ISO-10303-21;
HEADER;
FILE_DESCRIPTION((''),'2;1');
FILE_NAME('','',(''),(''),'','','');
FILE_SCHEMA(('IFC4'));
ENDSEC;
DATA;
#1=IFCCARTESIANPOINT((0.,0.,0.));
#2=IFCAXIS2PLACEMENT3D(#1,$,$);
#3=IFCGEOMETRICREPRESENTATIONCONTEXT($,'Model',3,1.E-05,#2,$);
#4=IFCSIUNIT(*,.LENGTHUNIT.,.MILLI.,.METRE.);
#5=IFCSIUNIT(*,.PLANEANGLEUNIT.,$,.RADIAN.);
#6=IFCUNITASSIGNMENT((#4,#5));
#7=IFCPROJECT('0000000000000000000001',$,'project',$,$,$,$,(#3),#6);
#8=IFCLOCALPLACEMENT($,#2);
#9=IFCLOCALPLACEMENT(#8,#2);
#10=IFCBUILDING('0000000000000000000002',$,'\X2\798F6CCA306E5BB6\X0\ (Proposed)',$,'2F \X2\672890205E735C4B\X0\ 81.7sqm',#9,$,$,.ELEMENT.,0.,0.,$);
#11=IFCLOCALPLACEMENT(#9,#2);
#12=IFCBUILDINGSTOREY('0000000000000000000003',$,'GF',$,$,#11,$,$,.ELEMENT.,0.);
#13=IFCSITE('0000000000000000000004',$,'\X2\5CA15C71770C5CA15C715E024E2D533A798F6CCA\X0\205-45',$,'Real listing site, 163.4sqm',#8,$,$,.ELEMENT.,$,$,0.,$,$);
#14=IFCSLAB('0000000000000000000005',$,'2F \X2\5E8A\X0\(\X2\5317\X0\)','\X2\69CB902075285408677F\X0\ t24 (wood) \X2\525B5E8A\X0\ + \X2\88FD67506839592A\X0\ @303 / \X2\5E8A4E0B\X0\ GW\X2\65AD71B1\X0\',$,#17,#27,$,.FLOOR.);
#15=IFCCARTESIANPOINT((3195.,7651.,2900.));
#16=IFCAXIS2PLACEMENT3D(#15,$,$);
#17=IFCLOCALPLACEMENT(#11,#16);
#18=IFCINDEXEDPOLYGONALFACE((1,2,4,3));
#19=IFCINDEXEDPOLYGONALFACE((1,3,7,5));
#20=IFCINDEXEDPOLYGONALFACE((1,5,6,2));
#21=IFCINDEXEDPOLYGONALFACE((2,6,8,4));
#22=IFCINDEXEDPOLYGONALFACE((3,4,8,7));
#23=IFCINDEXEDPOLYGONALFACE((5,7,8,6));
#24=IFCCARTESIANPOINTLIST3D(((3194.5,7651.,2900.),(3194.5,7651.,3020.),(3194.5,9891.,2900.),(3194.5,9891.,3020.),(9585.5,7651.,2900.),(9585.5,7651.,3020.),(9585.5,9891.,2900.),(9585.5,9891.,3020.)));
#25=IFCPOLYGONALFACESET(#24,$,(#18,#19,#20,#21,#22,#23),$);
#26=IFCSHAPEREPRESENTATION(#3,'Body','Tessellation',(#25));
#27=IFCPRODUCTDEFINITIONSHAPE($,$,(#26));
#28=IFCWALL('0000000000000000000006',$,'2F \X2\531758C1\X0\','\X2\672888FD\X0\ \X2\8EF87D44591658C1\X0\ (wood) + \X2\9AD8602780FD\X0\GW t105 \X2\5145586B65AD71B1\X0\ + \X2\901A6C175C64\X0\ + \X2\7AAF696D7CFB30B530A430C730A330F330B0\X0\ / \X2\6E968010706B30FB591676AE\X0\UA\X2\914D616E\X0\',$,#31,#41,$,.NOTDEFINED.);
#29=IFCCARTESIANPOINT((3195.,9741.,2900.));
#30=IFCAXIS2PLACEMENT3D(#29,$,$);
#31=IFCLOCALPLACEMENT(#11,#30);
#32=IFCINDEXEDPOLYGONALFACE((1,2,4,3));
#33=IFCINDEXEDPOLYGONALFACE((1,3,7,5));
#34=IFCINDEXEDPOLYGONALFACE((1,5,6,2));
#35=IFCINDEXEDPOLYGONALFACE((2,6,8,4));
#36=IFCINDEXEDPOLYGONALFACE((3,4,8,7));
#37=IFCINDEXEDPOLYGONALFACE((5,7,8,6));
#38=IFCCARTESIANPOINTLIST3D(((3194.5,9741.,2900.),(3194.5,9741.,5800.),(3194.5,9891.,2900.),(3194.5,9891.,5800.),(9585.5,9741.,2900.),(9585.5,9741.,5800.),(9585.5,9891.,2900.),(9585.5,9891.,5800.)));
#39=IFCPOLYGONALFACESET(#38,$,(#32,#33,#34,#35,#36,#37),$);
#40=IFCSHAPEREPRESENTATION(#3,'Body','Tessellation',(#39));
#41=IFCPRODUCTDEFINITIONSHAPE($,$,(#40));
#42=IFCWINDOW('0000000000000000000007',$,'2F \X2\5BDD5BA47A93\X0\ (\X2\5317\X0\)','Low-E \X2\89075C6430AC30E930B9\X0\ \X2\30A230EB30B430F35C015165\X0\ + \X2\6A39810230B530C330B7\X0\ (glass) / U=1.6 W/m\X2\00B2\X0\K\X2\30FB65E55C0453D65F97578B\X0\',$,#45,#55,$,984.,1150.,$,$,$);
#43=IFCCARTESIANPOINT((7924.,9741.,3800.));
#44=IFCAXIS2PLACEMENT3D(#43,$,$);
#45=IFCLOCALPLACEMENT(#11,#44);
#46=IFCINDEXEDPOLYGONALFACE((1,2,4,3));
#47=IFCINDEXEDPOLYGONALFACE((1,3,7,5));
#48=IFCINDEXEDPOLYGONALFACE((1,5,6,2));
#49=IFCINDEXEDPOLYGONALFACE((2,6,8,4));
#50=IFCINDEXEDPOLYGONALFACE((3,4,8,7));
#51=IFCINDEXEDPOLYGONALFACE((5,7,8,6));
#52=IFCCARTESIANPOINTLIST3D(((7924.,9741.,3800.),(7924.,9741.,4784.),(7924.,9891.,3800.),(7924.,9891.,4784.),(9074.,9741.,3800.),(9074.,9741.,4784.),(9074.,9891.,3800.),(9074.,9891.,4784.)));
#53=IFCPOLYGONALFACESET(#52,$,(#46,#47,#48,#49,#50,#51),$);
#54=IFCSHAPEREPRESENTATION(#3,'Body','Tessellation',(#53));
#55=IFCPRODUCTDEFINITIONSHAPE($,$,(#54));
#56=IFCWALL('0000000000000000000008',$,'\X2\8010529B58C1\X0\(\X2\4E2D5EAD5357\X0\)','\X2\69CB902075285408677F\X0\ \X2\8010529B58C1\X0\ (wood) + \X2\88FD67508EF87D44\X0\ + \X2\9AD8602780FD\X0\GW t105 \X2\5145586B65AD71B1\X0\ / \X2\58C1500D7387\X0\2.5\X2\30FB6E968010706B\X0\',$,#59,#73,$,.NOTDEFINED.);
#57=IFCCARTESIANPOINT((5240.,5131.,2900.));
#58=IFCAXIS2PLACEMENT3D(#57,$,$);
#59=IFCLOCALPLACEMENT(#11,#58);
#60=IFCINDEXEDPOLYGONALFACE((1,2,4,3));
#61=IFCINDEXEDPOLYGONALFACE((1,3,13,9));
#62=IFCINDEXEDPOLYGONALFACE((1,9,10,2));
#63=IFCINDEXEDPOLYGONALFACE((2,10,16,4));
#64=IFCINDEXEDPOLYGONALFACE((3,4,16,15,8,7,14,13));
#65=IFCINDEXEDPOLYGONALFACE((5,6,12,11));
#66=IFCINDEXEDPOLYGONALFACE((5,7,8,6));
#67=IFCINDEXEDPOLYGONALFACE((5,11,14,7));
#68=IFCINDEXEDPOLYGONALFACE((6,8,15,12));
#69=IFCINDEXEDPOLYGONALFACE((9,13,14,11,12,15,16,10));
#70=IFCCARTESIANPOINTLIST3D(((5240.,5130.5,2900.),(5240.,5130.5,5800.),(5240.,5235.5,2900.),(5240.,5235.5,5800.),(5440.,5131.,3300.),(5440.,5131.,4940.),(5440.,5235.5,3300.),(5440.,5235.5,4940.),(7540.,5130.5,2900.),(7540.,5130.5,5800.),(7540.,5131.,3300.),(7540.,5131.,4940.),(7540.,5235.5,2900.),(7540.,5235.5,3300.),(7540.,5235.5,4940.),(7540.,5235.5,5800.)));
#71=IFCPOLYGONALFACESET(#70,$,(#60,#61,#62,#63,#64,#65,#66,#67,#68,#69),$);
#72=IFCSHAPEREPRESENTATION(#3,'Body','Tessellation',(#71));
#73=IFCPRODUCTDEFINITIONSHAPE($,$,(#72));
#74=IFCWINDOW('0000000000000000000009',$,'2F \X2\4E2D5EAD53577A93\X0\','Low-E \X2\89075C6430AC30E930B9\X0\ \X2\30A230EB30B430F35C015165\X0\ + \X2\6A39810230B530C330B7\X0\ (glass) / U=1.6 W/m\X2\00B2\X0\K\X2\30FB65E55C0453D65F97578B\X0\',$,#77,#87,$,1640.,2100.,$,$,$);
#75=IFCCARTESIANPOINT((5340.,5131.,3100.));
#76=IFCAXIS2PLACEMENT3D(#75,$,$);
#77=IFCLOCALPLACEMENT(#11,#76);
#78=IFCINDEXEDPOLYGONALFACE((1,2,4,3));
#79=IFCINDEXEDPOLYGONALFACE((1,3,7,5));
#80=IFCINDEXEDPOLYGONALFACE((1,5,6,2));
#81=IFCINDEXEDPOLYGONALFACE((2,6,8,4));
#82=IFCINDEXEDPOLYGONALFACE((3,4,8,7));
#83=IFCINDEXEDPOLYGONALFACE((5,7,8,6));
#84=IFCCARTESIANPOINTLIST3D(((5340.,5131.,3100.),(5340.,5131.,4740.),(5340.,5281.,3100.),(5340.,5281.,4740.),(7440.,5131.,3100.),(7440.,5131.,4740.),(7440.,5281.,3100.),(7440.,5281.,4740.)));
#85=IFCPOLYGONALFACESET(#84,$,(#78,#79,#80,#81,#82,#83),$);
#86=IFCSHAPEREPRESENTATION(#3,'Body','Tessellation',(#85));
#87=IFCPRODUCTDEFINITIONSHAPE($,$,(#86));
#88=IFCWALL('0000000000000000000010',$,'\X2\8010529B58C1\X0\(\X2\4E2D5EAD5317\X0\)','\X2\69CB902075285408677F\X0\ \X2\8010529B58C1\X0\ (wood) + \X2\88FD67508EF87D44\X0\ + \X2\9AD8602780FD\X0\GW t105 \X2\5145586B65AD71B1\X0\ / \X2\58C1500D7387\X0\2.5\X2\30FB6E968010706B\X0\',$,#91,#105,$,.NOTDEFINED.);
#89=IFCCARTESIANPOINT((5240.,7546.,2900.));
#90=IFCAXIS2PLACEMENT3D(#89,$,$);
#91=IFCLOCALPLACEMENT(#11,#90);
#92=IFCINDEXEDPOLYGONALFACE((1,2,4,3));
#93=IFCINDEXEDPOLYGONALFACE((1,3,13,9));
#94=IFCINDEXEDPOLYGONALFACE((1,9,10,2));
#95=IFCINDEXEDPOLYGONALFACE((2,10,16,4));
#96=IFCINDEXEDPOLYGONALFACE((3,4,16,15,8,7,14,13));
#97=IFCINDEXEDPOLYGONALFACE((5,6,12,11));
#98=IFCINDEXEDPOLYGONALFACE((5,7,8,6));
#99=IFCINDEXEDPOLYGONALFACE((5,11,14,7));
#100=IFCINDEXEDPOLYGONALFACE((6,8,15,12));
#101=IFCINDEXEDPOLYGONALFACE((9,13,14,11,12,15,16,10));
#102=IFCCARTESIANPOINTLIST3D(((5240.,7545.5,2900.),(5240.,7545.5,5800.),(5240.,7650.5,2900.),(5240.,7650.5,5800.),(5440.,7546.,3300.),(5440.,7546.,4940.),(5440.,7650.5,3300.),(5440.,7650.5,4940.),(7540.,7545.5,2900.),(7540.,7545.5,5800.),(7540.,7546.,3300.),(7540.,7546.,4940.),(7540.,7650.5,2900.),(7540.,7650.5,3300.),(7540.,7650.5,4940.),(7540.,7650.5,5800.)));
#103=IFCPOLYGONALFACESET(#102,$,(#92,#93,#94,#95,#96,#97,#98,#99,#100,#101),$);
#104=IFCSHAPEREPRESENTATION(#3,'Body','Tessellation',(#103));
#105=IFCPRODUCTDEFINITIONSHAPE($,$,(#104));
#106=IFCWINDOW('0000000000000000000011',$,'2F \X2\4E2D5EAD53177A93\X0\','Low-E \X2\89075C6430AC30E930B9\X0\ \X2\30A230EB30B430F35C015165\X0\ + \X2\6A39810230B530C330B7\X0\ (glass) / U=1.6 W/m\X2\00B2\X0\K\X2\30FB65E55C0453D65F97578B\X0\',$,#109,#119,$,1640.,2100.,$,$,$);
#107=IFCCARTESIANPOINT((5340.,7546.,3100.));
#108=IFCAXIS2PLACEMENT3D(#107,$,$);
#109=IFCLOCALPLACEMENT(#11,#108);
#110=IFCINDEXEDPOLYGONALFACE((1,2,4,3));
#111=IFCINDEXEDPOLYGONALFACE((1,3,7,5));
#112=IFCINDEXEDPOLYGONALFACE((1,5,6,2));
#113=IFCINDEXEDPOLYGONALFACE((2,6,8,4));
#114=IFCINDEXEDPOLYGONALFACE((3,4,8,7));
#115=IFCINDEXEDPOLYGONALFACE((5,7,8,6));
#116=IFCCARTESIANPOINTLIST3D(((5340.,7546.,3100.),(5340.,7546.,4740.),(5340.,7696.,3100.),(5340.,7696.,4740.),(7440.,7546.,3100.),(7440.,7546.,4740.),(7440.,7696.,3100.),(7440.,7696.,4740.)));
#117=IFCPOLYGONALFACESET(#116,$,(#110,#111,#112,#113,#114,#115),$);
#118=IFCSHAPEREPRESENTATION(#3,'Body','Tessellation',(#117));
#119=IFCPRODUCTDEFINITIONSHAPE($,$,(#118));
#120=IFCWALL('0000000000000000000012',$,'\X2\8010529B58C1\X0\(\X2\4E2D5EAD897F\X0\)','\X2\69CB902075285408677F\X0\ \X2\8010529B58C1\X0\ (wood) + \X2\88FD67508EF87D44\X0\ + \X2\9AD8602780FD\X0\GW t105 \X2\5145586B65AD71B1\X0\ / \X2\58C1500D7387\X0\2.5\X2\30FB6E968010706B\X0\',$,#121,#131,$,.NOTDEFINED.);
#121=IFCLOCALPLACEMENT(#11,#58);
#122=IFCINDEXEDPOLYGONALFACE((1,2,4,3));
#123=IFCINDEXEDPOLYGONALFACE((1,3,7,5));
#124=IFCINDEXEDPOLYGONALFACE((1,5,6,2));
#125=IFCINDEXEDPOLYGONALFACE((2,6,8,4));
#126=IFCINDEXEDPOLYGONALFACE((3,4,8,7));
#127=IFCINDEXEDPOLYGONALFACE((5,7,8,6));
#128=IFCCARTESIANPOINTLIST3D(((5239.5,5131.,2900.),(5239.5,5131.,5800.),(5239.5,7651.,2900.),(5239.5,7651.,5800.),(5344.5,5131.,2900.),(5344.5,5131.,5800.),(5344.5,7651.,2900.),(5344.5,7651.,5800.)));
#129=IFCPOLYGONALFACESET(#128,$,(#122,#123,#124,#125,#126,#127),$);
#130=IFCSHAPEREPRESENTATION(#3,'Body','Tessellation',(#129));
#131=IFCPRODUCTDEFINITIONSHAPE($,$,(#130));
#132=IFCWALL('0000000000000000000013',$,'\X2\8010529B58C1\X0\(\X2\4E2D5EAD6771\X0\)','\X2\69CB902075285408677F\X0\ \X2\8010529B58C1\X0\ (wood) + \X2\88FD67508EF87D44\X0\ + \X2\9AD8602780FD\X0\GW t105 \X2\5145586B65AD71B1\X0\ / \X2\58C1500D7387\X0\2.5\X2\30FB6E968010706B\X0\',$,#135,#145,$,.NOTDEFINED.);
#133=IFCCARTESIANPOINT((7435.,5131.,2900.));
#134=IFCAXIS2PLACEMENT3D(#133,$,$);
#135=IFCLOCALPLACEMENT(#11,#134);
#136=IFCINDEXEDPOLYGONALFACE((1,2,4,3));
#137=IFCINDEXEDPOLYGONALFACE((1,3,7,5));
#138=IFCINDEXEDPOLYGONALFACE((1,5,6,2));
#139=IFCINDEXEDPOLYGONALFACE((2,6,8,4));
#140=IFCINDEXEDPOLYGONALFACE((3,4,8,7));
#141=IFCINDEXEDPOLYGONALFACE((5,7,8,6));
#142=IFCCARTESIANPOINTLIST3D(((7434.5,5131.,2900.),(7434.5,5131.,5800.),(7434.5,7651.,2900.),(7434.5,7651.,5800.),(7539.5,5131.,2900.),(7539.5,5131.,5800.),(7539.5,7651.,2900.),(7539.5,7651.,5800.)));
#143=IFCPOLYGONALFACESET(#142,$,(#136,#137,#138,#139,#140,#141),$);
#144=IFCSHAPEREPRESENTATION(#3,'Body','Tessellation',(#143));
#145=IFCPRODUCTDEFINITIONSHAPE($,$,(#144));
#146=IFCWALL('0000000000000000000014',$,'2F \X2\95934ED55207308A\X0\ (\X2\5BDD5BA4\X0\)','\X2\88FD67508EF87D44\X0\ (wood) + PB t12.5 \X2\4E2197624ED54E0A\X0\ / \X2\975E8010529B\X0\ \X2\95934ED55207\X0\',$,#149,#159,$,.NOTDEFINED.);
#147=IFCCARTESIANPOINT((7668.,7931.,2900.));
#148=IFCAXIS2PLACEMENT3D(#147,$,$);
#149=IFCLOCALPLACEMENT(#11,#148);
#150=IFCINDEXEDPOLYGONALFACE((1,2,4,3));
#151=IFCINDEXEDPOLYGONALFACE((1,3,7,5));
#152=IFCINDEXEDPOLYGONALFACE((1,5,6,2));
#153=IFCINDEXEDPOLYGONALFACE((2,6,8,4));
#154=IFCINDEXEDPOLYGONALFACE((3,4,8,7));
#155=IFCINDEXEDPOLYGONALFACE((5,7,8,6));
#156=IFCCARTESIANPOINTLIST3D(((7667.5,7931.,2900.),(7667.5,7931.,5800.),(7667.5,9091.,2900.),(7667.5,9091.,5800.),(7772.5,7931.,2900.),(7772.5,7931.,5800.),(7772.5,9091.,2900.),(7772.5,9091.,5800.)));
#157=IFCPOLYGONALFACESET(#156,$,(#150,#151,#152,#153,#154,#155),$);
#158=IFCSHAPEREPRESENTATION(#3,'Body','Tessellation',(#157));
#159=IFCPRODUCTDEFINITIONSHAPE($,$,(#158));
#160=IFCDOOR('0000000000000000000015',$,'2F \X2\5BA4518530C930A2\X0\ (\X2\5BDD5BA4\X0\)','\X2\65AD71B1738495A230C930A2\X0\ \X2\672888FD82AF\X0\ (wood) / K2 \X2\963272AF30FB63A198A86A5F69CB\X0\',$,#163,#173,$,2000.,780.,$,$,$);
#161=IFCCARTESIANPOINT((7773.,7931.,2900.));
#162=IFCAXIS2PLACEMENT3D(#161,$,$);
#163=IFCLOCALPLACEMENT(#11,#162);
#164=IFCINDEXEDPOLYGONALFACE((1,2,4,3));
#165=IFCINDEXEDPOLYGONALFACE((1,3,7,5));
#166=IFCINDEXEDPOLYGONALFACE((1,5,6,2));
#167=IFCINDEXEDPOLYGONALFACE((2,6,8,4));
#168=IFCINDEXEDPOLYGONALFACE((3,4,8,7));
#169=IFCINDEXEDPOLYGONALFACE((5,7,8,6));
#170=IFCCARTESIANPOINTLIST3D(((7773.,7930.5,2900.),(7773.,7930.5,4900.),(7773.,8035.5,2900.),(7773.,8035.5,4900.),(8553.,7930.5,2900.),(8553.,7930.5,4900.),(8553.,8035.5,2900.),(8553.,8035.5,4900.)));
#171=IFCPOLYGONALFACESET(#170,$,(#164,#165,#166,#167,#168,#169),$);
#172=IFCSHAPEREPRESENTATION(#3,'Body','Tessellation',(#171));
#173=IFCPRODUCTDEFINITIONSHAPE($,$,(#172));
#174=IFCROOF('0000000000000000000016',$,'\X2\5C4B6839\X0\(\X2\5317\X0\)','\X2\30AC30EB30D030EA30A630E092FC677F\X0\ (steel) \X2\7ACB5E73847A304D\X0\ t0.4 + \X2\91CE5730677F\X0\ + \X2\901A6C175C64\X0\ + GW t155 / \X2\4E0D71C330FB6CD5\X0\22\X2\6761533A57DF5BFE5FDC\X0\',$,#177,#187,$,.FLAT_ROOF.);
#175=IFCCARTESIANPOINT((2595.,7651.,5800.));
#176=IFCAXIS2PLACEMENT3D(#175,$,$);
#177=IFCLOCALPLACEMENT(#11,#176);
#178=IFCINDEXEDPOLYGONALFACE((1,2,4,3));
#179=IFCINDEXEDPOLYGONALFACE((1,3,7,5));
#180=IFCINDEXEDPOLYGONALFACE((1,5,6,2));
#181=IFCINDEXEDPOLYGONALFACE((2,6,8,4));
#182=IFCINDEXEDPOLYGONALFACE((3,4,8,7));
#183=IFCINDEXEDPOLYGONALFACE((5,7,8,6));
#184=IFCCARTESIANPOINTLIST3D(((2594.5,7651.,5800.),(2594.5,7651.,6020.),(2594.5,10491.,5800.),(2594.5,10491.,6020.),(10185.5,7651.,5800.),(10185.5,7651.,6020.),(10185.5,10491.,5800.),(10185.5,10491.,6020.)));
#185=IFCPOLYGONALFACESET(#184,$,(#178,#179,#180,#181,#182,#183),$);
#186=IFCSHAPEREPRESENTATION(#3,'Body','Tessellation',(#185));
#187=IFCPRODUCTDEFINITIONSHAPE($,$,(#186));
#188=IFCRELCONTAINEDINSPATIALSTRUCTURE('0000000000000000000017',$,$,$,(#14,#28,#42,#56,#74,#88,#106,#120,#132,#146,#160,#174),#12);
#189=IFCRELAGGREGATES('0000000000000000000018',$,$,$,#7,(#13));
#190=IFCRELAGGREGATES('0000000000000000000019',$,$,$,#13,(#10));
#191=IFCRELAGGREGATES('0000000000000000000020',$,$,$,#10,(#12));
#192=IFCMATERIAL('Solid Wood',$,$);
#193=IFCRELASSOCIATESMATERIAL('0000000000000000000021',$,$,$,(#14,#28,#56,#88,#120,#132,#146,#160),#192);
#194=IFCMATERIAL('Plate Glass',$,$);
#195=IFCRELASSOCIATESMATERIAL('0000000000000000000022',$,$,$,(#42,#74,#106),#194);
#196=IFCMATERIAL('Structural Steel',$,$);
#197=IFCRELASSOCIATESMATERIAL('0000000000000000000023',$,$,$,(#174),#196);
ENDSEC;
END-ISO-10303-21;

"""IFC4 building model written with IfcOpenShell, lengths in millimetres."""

from ifc_helpers import new_model, si_unit, frame, frame_2d, origin, place, context, project, spatial, rectangle, extrude, material, element, fill, save


model = new_model("IFC4")

# Units and contexts
model_context = context("Model", 3, precision=1e-05, world=origin())
ifc_project = project(units=[si_unit("LENGTHUNIT", "METRE", prefix="MILLI"), si_unit("PLANEANGLEUNIT", "RADIAN")], contexts=[model_context])

# Site, building, storey
site_placement = place(None, origin())
site = spatial("IfcSite", under=ifc_project, at=site_placement, Name="岡山県岡山市中区福泊205-45", ObjectType="Real listing site, 163.4sqm", CompositionType="ELEMENT", RefElevation=0.0)
building_placement = place(site_placement, origin())
building = spatial("IfcBuilding", under=site, at=building_placement, Name="福泊の家 (Proposed)", ObjectType="2F 木造平屋 81.7sqm", CompositionType="ELEMENT", ElevationOfRefHeight=0.0, ElevationOfTerrain=0.0)
storey_placement = place(building_placement, origin())
storey = spatial("IfcBuildingStorey", under=building, at=storey_placement, Name="GF", CompositionType="ELEMENT", Elevation=0.0)

# Slab
ifc_material_1 = material(Name="Solid Wood")
slab_placement = place(storey_placement, frame((3195.0, 7651.0, 2900.0)))
element("IfcSlab", 1, at=slab_placement, inside=storey, material=ifc_material_1, Name="2F 床(北)", Description="構造用合板 t24 (wood) 剛床 + 製材根太 @303 / 床下 GW断熱", PredefinedType="FLOOR", context=model_context, shape_type="SweptSolid", body=[
    extrude(rectangle(XDim=6391.0, YDim=2240.0, at=frame_2d((3195.0, 1120.0))), frame((3195.0, 7651.0, 2900.0)), (0.0, 0.0, 1.0), 120.0),
])

# Walls, openings, windows
wall_1_placement = place(storey_placement, frame((3195.0, 9741.0, 2900.0)))
wall_1 = element("IfcWall", 2, at=wall_1_placement, inside=storey, material=ifc_material_1, Name="2F 北壁", Description="木製 軸組外壁 (wood) + 高性能GW t105 充填断熱 + 通気層 + 窯業系サイディング / 準耐火・外皮UA配慮", PredefinedType="NOTDEFINED", context=model_context, shape_type="SweptSolid", body=[
    extrude(rectangle(XDim=6391.0, YDim=150.0, at=frame_2d((3195.0, 75.0))), frame((3195.0, 9741.0, 2900.0)), (0.0, 0.0, 1.0), 2900.0),
])
opening_1_placement = place(storey_placement, frame((7924.0, 9741.0, 3800.0)))
opening_1 = element("IfcOpeningElement", 3, at=opening_1_placement, cuts=wall_1, PredefinedType="NOTDEFINED", context=model_context, shape_type="SweptSolid", body=[
    extrude(rectangle(XDim=1150.0, YDim=150.0, at=frame_2d((575.0, 75.0))), frame((7924.0, 9741.0, 3800.0)), (0.0, 0.0, 1.0), 984.0),
])
ifc_material_2 = material(Name="Plate Glass")
window_1_placement = place(storey_placement, frame((7924.0, 9741.0, 3800.0)))
window_1 = element("IfcWindow", 4, at=window_1_placement, inside=storey, material=ifc_material_2, Name="2F 寝室窓 (北)", Description="Low-E 複層ガラス アルゴン封入 + 樹脂サッシ (glass) / U=1.6 W/m²K・日射取得型", OverallHeight=984.0, OverallWidth=1150.0, context=model_context, shape_type="SweptSolid", body=[
    extrude(rectangle(XDim=1150.0, YDim=150.0, at=frame_2d((575.0, 75.0))), frame((7924.0, 9741.0, 3800.0)), (0.0, 0.0, 1.0), 984.0),
])
fill(opening_1, window_1)
wall_2_placement = place(storey_placement, frame((5240.0, 5131.0, 2900.0)))
wall_2 = element("IfcWall", 5, at=wall_2_placement, inside=storey, material=ifc_material_1, Name="耐力壁(中庭南)", Description="構造用合板 耐力壁 (wood) + 製材軸組 + 高性能GW t105 充填断熱 / 壁倍率2.5・準耐火", PredefinedType="NOTDEFINED", context=model_context, shape_type="SweptSolid", body=[
    extrude(rectangle(XDim=2300.0, YDim=105.0, at=frame_2d((1150.0, 52.0))), frame((5240.0, 5131.0, 2900.0)), (0.0, 0.0, 1.0), 2900.0),
])
opening_2_placement = place(storey_placement, frame((5340.0, 5131.0, 3100.0)))
opening_2 = element("IfcOpeningElement", 6, at=opening_2_placement, cuts=wall_2, PredefinedType="NOTDEFINED", context=model_context, shape_type="SweptSolid", body=[
    extrude(rectangle(XDim=2100.0, YDim=150.0, at=frame_2d((1050.0, 75.0))), frame((5340.0, 5131.0, 3100.0)), (0.0, 0.0, 1.0), 1640.0),
])
window_2_placement = place(storey_placement, frame((5340.0, 5131.0, 3100.0)))
window_2 = element("IfcWindow", 7, at=window_2_placement, inside=storey, material=ifc_material_2, Name="2F 中庭南窓", Description="Low-E 複層ガラス アルゴン封入 + 樹脂サッシ (glass) / U=1.6 W/m²K・日射取得型", OverallHeight=1640.0, OverallWidth=2100.0, context=model_context, shape_type="SweptSolid", body=[
    extrude(rectangle(XDim=2100.0, YDim=150.0, at=frame_2d((1050.0, 75.0))), frame((5340.0, 5131.0, 3100.0)), (0.0, 0.0, 1.0), 1640.0),
])
fill(opening_2, window_2)
wall_3_placement = place(storey_placement, frame((5240.0, 7546.0, 2900.0)))
wall_3 = element("IfcWall", 8, at=wall_3_placement, inside=storey, material=ifc_material_1, Name="耐力壁(中庭北)", Description="構造用合板 耐力壁 (wood) + 製材軸組 + 高性能GW t105 充填断熱 / 壁倍率2.5・準耐火", PredefinedType="NOTDEFINED", context=model_context, shape_type="SweptSolid", body=[
    extrude(rectangle(XDim=2300.0, YDim=105.0, at=frame_2d((1150.0, 52.0))), frame((5240.0, 7546.0, 2900.0)), (0.0, 0.0, 1.0), 2900.0),
])
opening_3_placement = place(storey_placement, frame((5340.0, 7546.0, 3100.0)))
opening_3 = element("IfcOpeningElement", 9, at=opening_3_placement, cuts=wall_3, PredefinedType="NOTDEFINED", context=model_context, shape_type="SweptSolid", body=[
    extrude(rectangle(XDim=2100.0, YDim=150.0, at=frame_2d((1050.0, 75.0))), frame((5340.0, 7546.0, 3100.0)), (0.0, 0.0, 1.0), 1640.0),
])
window_3_placement = place(storey_placement, frame((5340.0, 7546.0, 3100.0)))
window_3 = element("IfcWindow", 10, at=window_3_placement, inside=storey, material=ifc_material_2, Name="2F 中庭北窓", Description="Low-E 複層ガラス アルゴン封入 + 樹脂サッシ (glass) / U=1.6 W/m²K・日射取得型", OverallHeight=1640.0, OverallWidth=2100.0, context=model_context, shape_type="SweptSolid", body=[
    extrude(rectangle(XDim=2100.0, YDim=150.0, at=frame_2d((1050.0, 75.0))), frame((5340.0, 7546.0, 3100.0)), (0.0, 0.0, 1.0), 1640.0),
])
fill(opening_3, window_3)

# Walls
wall_4_placement = place(storey_placement, frame((5240.0, 5131.0, 2900.0)))
element("IfcWall", 11, at=wall_4_placement, inside=storey, material=ifc_material_1, Name="耐力壁(中庭西)", Description="構造用合板 耐力壁 (wood) + 製材軸組 + 高性能GW t105 充填断熱 / 壁倍率2.5・準耐火", PredefinedType="NOTDEFINED", context=model_context, shape_type="SweptSolid", body=[
    extrude(rectangle(XDim=105.0, YDim=2520.0, at=frame_2d((52.0, 1260.0))), frame((5240.0, 5131.0, 2900.0)), (0.0, 0.0, 1.0), 2900.0),
])
wall_5_placement = place(storey_placement, frame((7435.0, 5131.0, 2900.0)))
element("IfcWall", 12, at=wall_5_placement, inside=storey, material=ifc_material_1, Name="耐力壁(中庭東)", Description="構造用合板 耐力壁 (wood) + 製材軸組 + 高性能GW t105 充填断熱 / 壁倍率2.5・準耐火", PredefinedType="NOTDEFINED", context=model_context, shape_type="SweptSolid", body=[
    extrude(rectangle(XDim=105.0, YDim=2520.0, at=frame_2d((52.0, 1260.0))), frame((7435.0, 5131.0, 2900.0)), (0.0, 0.0, 1.0), 2900.0),
])
wall_6_placement = place(storey_placement, frame((7668.0, 7931.0, 2900.0)))
element("IfcWall", 13, at=wall_6_placement, inside=storey, material=ifc_material_1, Name="2F 間仕切り (寝室)", Description="製材軸組 (wood) + PB t12.5 両面仕上 / 非耐力 間仕切", PredefinedType="NOTDEFINED", context=model_context, shape_type="SweptSolid", body=[
    extrude(rectangle(XDim=105.0, YDim=1160.0, at=frame_2d((52.0, 580.0))), frame((7668.0, 7931.0, 2900.0)), (0.0, 0.0, 1.0), 2900.0),
])

# Door
door_placement = place(storey_placement, frame((7773.0, 7931.0, 2900.0)))
element("IfcDoor", 14, at=door_placement, inside=storey, material=ifc_material_1, Name="2F 室内ドア (寝室)", Description="断熱玄関ドア 木製芯 (wood) / K2 防犯・採風機構", OverallHeight=2000.0, OverallWidth=780.0, context=model_context, shape_type="SweptSolid", body=[
    extrude(rectangle(XDim=780.0, YDim=105.0, at=frame_2d((390.0, 52.0))), frame((7773.0, 7931.0, 2900.0)), (0.0, 0.0, 1.0), 2000.0),
])

# Roof
ifc_material_3 = material(Name="Structural Steel")
for number, where, name in (
    (15, (2595.0, 7651.0, 5800.0), "屋根(北)"),
):
    element("IfcRoof", number, at=place(storey_placement, frame(where)), inside=storey, material=ifc_material_3, Name=name, Description="ガルバリウム鋼板 (steel) 立平葺き t0.4 + 野地板 + 通気層 + GW t155 / 不燃・法22条区域対応", PredefinedType="FLAT_ROOF", context=model_context, shape_type="SweptSolid", body=[
        extrude(rectangle(XDim=7591.0, YDim=2840.0, at=frame_2d((3795.0, 1420.0))), frame((2595.0, 7651.0, 5800.0)), (0.0, 0.0, 1.0), 220.0),
    ])

save(model, "model.ifc")
